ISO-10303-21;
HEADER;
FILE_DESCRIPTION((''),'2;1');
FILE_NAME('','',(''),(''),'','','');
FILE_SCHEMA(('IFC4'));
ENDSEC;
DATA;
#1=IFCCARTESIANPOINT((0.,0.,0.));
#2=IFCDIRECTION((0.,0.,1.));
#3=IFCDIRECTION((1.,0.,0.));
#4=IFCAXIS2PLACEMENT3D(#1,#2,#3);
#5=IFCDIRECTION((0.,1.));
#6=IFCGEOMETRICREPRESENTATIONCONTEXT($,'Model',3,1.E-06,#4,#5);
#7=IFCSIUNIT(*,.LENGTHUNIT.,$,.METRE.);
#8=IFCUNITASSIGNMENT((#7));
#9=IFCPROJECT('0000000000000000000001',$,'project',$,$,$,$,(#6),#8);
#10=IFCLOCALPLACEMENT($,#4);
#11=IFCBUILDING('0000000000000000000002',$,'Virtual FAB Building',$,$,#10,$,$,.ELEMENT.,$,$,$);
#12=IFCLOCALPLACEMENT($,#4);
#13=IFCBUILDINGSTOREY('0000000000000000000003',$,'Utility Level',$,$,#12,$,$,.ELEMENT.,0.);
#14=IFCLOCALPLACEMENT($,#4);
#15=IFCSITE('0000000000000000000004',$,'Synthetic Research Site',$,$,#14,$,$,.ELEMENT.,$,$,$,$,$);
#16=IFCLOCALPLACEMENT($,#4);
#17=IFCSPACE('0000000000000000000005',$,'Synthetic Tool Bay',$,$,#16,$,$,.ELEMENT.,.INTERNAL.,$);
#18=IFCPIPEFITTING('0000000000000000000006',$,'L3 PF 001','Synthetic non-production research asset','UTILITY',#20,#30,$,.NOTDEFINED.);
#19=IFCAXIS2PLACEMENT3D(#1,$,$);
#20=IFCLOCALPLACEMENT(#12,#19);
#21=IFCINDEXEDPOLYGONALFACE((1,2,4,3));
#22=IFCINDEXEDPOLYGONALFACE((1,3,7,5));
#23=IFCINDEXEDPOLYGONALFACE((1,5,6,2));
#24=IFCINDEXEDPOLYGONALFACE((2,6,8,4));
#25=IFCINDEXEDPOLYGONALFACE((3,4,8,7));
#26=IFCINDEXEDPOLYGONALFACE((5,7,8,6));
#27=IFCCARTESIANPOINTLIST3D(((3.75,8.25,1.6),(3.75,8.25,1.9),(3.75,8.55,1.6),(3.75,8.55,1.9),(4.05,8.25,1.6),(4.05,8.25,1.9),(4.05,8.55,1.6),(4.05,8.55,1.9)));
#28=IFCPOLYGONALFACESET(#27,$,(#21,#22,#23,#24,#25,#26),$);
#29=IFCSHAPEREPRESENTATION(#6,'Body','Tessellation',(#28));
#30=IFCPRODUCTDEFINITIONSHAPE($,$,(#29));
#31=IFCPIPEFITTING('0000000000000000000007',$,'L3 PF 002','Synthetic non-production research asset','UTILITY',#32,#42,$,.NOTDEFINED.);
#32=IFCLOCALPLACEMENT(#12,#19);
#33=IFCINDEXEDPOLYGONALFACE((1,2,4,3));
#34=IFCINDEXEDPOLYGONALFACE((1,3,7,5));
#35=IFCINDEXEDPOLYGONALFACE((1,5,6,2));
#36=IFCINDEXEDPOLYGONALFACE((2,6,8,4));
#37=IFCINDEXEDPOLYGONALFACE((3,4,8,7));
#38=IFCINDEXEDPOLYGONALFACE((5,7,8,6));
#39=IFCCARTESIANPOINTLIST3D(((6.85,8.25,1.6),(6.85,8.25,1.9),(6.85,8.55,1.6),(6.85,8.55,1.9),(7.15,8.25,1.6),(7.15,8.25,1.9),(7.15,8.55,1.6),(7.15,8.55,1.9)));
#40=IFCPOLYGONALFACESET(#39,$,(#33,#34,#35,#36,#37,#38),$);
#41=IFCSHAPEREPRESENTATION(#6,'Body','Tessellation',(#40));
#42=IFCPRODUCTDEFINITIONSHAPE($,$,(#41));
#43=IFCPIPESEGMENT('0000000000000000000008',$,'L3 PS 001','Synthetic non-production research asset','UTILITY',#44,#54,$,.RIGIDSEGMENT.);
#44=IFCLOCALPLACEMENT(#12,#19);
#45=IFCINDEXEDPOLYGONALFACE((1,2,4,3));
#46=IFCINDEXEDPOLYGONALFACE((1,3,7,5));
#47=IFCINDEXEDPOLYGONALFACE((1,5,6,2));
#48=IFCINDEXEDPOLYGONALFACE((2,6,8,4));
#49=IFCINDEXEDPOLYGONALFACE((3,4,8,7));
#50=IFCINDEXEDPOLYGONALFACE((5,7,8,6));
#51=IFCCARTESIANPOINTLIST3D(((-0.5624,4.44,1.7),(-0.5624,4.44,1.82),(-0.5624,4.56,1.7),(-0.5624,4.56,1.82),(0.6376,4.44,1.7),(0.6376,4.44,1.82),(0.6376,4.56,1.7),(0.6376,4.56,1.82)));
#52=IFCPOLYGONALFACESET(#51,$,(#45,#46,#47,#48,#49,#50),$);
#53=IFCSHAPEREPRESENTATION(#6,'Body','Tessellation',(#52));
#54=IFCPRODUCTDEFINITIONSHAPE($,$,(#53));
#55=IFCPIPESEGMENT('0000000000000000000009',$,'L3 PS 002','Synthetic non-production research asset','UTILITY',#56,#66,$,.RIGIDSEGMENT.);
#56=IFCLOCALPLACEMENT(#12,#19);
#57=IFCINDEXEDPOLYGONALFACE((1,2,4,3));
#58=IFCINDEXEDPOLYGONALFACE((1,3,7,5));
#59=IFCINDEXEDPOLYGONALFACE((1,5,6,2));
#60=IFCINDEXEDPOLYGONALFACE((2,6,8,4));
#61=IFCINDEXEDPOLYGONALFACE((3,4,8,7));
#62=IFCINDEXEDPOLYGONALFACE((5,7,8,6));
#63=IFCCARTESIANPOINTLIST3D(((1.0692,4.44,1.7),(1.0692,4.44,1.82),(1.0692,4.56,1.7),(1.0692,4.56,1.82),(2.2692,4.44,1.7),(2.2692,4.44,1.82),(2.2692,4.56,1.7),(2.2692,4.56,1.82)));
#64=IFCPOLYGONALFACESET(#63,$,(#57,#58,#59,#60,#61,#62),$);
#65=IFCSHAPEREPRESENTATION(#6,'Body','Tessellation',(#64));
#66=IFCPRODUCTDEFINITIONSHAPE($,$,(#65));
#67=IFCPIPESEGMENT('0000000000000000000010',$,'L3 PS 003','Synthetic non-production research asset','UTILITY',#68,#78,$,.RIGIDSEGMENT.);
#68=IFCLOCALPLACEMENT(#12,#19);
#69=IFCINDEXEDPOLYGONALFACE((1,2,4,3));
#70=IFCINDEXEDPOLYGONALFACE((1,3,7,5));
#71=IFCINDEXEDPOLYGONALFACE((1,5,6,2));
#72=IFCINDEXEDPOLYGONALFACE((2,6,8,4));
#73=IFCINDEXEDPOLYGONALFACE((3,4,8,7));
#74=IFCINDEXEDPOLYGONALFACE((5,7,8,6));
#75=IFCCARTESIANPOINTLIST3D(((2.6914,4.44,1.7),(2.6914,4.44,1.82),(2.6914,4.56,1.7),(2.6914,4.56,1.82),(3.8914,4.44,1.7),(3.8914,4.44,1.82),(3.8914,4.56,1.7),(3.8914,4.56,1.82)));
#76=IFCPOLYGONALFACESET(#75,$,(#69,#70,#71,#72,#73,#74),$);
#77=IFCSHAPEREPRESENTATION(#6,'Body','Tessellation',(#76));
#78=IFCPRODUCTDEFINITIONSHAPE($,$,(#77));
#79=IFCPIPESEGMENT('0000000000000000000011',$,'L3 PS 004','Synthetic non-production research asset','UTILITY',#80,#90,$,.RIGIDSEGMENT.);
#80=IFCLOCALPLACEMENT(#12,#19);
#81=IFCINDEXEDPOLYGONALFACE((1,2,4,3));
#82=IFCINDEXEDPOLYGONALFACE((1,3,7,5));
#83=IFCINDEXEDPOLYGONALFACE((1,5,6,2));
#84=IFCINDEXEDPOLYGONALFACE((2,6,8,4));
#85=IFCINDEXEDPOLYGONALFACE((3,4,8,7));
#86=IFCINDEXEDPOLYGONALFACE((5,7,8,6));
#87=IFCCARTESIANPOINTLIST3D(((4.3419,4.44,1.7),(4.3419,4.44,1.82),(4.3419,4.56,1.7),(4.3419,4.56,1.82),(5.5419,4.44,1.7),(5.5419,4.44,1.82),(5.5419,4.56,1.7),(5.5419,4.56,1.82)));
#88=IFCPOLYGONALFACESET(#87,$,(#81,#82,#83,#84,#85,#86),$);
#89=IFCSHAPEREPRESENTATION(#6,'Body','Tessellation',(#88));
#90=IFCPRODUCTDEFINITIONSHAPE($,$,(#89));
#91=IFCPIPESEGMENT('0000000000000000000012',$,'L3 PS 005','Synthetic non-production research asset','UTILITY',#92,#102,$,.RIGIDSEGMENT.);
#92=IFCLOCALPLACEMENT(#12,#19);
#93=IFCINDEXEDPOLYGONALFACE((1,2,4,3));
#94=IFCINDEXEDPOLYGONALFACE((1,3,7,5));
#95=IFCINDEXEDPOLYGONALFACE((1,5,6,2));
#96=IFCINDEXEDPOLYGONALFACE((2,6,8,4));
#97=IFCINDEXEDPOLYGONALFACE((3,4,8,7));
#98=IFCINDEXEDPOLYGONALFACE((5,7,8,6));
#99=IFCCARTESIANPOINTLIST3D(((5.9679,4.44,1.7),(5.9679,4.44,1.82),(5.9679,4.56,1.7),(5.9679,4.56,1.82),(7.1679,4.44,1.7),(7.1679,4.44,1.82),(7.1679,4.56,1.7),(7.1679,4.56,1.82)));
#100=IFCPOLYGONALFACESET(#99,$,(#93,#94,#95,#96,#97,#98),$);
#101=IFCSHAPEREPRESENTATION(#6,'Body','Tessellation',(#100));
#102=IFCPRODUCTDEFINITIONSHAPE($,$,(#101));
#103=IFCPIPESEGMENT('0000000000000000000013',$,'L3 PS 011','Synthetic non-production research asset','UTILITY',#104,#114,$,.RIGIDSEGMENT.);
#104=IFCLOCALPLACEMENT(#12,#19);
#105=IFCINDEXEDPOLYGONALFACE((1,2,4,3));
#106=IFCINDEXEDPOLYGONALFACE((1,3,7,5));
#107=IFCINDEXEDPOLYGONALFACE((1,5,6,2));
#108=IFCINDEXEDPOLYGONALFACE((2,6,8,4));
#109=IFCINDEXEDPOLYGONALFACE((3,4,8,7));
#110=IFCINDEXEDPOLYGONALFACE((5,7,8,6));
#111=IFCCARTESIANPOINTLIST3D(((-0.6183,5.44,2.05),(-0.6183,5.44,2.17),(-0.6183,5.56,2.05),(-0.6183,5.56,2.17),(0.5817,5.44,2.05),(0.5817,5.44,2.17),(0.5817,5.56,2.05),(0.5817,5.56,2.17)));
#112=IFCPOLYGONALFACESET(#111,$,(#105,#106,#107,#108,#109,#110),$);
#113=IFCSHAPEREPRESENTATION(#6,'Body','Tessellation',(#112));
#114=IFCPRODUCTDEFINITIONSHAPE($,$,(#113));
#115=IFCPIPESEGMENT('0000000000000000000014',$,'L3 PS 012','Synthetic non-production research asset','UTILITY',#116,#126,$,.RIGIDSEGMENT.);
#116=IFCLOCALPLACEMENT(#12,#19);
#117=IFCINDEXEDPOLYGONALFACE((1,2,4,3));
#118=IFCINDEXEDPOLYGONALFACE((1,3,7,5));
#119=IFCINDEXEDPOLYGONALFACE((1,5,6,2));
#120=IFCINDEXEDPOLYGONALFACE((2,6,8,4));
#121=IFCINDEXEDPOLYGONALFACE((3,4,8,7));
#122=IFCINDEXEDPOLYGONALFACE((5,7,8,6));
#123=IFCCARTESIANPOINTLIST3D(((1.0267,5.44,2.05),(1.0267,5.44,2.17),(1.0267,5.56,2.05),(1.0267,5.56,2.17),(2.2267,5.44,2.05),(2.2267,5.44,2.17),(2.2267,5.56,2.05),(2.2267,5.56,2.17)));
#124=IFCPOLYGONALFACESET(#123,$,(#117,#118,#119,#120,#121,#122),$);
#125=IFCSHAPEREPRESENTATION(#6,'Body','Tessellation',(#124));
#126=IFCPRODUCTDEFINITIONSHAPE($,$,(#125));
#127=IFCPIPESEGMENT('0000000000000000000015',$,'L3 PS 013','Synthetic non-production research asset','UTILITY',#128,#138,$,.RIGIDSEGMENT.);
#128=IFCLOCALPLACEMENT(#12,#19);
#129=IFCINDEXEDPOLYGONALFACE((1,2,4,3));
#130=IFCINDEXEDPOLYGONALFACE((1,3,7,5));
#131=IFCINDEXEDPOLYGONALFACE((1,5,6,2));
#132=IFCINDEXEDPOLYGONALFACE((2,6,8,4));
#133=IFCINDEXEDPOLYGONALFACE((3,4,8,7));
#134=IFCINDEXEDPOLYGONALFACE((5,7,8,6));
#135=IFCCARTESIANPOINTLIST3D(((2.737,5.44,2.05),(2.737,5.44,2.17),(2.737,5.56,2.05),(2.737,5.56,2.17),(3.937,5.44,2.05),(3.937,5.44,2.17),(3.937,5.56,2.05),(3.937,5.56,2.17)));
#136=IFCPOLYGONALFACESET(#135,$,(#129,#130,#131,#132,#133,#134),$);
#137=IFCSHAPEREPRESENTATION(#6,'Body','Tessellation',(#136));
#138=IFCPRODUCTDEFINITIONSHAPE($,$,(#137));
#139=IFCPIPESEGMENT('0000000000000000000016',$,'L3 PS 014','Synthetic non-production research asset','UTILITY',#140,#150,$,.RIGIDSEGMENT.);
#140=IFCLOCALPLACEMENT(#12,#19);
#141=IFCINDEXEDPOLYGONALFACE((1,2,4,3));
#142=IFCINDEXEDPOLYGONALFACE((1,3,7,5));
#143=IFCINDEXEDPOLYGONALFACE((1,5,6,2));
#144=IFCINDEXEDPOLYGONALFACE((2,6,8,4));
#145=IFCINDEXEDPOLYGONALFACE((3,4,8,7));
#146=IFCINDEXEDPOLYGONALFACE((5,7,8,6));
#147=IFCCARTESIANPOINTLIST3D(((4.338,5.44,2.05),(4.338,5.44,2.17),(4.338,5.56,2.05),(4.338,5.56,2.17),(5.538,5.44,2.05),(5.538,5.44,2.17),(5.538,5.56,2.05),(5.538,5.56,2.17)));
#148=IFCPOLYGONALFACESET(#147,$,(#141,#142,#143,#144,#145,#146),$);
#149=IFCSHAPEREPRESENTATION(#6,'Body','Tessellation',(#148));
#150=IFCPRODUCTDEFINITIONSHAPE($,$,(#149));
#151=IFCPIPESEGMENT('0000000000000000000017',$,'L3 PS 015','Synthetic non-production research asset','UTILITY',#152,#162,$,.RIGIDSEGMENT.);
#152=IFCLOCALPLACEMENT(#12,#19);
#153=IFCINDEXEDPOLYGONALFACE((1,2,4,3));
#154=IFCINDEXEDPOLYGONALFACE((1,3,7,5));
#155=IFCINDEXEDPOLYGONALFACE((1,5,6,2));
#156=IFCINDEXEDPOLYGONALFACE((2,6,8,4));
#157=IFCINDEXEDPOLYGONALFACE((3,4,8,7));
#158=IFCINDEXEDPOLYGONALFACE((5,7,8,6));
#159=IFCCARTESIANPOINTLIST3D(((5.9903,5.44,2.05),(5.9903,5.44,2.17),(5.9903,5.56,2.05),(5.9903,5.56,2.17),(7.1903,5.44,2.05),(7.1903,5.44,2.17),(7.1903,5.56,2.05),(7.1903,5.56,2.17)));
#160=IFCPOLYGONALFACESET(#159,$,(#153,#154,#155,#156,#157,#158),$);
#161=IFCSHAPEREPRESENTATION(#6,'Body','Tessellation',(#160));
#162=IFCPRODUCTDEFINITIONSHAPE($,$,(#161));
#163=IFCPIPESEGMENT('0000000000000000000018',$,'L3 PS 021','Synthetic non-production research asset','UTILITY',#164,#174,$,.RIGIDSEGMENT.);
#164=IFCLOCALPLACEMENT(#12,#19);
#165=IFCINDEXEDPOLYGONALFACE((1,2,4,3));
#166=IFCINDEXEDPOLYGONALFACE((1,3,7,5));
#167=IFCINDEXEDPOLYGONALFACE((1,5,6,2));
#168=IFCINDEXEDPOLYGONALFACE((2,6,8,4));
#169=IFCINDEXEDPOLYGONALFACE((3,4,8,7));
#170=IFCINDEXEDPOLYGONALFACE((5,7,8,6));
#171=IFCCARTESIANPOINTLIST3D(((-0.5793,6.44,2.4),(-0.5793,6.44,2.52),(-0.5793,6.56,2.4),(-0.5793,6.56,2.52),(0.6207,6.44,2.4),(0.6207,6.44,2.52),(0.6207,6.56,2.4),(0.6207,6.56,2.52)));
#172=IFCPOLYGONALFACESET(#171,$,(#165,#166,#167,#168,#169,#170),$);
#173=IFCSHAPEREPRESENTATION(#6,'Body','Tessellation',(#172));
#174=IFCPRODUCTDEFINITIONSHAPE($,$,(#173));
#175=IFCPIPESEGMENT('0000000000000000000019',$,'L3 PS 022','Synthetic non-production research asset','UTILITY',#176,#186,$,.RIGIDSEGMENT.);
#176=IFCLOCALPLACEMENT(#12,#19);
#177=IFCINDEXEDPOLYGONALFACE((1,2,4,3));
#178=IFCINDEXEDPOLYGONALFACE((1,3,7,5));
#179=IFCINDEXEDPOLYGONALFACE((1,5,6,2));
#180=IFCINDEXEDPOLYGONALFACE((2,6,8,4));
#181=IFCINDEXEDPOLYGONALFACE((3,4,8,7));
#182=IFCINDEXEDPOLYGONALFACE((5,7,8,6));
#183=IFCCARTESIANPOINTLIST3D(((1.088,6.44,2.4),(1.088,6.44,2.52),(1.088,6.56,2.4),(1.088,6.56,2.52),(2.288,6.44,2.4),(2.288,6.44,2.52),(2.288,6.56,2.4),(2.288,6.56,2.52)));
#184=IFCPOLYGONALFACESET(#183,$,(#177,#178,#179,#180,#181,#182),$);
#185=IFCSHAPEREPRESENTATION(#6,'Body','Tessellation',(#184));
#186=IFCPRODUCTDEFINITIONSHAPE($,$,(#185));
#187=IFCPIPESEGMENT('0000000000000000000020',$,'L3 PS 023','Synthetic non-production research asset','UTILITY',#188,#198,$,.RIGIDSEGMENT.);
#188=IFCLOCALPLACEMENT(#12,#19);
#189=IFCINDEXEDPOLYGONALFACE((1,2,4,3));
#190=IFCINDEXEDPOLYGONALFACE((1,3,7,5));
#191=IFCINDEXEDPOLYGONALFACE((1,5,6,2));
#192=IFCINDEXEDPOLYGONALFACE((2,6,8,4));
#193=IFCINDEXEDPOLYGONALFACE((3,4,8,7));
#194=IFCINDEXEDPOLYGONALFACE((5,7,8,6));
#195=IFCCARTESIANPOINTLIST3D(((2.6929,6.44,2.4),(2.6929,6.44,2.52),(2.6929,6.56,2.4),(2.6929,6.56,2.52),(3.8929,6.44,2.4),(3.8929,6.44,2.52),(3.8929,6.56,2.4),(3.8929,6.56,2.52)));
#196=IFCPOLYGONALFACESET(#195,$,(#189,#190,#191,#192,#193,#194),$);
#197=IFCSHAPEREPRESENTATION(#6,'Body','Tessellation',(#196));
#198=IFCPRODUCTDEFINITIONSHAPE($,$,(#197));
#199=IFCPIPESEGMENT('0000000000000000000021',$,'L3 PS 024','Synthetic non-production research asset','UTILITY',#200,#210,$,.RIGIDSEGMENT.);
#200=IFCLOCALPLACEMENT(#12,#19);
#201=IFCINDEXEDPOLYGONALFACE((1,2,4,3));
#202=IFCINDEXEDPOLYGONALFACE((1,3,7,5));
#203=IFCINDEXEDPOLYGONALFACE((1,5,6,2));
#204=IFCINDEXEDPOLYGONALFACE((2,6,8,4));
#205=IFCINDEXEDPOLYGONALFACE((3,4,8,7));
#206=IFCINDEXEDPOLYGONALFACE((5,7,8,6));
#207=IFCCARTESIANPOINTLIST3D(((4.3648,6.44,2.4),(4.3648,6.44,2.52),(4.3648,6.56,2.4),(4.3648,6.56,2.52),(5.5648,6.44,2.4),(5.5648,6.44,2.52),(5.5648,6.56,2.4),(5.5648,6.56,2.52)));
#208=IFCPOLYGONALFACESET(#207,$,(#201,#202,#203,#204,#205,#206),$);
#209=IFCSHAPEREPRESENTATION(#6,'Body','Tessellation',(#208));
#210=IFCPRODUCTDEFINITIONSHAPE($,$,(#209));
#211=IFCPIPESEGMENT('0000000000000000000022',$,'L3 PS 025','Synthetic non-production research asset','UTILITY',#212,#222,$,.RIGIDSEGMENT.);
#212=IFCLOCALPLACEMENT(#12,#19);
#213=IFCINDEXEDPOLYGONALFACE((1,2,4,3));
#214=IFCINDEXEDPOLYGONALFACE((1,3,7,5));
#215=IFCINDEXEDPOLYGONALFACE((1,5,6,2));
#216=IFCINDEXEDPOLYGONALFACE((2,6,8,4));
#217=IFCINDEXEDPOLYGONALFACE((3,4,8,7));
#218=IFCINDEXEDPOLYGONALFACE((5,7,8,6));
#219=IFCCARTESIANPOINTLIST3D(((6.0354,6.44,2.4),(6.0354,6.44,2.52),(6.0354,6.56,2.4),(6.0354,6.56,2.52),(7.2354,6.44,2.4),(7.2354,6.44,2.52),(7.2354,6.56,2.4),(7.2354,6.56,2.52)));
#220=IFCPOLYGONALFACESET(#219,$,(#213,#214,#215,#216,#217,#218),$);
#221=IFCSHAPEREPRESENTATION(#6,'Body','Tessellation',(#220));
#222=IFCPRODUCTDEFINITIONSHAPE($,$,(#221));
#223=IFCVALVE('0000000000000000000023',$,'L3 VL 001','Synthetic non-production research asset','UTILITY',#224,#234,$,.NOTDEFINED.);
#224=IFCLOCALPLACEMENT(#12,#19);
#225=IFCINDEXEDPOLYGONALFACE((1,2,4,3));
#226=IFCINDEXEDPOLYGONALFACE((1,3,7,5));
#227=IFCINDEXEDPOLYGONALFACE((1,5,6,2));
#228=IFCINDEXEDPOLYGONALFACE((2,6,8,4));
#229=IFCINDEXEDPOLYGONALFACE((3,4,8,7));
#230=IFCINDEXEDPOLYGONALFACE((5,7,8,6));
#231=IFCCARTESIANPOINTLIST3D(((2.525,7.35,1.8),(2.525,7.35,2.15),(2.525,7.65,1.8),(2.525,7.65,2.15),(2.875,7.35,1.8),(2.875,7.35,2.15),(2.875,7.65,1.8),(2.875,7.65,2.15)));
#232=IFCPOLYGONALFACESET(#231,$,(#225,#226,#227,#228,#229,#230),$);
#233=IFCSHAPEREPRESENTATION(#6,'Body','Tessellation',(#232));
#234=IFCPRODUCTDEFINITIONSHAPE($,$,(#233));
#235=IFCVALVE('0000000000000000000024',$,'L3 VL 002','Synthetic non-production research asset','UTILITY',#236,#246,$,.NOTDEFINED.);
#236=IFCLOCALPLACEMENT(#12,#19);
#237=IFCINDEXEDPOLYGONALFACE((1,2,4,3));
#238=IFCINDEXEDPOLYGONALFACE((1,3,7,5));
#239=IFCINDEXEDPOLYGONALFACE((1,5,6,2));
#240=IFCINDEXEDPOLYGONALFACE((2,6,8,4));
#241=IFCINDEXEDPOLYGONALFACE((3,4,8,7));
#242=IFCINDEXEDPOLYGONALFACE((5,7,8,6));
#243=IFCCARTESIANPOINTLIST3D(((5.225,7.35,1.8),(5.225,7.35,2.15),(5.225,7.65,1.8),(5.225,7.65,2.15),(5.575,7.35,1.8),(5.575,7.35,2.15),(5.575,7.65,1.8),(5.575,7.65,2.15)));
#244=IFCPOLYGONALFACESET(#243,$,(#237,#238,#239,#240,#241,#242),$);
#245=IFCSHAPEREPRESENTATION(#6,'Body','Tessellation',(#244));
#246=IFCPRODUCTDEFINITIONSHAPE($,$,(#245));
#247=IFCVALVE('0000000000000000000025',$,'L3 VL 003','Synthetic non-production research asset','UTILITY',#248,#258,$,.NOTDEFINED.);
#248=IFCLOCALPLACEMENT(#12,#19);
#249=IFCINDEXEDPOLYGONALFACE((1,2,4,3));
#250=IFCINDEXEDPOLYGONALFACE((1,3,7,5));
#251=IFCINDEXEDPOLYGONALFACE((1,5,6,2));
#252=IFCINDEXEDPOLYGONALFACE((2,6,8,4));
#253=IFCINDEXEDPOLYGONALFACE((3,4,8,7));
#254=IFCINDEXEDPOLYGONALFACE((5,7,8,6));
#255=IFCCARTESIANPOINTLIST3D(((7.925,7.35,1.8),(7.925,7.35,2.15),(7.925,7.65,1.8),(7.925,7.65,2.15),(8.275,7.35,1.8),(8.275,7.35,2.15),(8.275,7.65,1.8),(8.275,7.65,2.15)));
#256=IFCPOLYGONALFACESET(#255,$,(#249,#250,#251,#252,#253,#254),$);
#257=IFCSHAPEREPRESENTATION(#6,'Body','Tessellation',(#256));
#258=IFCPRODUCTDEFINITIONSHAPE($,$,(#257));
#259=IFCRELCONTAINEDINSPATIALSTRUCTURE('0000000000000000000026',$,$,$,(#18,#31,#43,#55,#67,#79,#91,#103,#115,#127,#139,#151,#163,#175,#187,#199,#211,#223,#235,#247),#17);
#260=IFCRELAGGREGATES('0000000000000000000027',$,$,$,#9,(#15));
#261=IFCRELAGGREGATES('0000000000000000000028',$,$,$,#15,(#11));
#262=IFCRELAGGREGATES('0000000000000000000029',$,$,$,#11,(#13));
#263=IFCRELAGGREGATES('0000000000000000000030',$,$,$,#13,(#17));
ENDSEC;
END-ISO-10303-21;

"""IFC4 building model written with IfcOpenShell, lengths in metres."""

from ifc_helpers import new_model, si_unit, direction, frame, origin_with_axes, origin_2d_with_axis, place, context, project, spatial, rectangle, extrude, element, save


model = new_model("IFC4")

# Units and contexts
model_context = context("Model", 3, precision=1e-06, world=origin_with_axes(), true_north=direction((0.0, 1.0)))
ifc_project = project(units=[si_unit("LENGTHUNIT", "METRE")], contexts=[model_context])

# Site, building, storey, space
site_placement = place(None, origin_with_axes())
site = spatial("IfcSite", under=ifc_project, at=site_placement, Name="Synthetic Research Site", CompositionType="ELEMENT")
building_placement = place(None, origin_with_axes())
building = spatial("IfcBuilding", under=site, at=building_placement, Name="Virtual FAB Building", CompositionType="ELEMENT")
storey_placement = place(None, origin_with_axes())
storey = spatial("IfcBuildingStorey", under=building, at=storey_placement, Name="Utility Level", CompositionType="ELEMENT", Elevation=0.0)
space_placement = place(None, origin_with_axes())
space = spatial("IfcSpace", under=storey, at=space_placement, Name="Synthetic Tool Bay", CompositionType="ELEMENT", PredefinedType="INTERNAL")

# Pipe fittings
for number, where, z_axis, x_axis, name in (
    (1, (3.9, 8.4, 1.6), (0.0, 0.0, 1.0), (1.0, 0.0, 0.0), "L3 PF 001"),
    (2, (7.0, 8.4, 1.6), (0.0, 0.0, 1.0), (1.0, 0.0, 0.0), "L3 PF 002"),
):
    element("IfcPipeFitting", number, at=place(None, frame(where, z_axis=z_axis, x_axis=x_axis)), inside=space, Name=name, Description="Synthetic non-production research asset", ObjectType="UTILITY", PredefinedType="NOTDEFINED", context=model_context, shape_type="SweptSolid", body=[
        extrude(rectangle(XDim=0.3, YDim=0.3, at=origin_2d_with_axis()), origin_with_axes(), (0.0, 0.0, 1.0), 0.3),
    ])

# Pipe segments
for number, where, z_axis, x_axis, name in (
    (3, (0.0376, 4.5, 1.7), (0.0, 0.0, 1.0), (1.0, 0.0, 0.0), "L3 PS 001"),
    (4, (1.6692, 4.5, 1.7), (0.0, 0.0, 1.0), (1.0, 0.0, 0.0), "L3 PS 002"),
    (5, (3.2914, 4.5, 1.7), (0.0, 0.0, 1.0), (1.0, 0.0, 0.0), "L3 PS 003"),
    (6, (4.9419, 4.5, 1.7), (0.0, 0.0, 1.0), (1.0, 0.0, 0.0), "L3 PS 004"),
    (7, (6.5679, 4.5, 1.7), (0.0, 0.0, 1.0), (1.0, 0.0, 0.0), "L3 PS 005"),
    (8, (-0.0183, 5.5, 2.05), (0.0, 0.0, 1.0), (1.0, 0.0, 0.0), "L3 PS 011"),
    (9, (1.6267, 5.5, 2.05), (0.0, 0.0, 1.0), (1.0, 0.0, 0.0), "L3 PS 012"),
    (10, (3.337, 5.5, 2.05), (0.0, 0.0, 1.0), (1.0, 0.0, 0.0), "L3 PS 013"),
    (11, (4.938, 5.5, 2.05), (0.0, 0.0, 1.0), (1.0, 0.0, 0.0), "L3 PS 014"),
    (12, (6.5903, 5.5, 2.05), (0.0, 0.0, 1.0), (1.0, 0.0, 0.0), "L3 PS 015"),
    (13, (0.0207, 6.5, 2.4), (0.0, 0.0, 1.0), (1.0, 0.0, 0.0), "L3 PS 021"),
    (14, (1.688, 6.5, 2.4), (0.0, 0.0, 1.0), (1.0, 0.0, 0.0), "L3 PS 022"),
    (15, (3.2929, 6.5, 2.4), (0.0, 0.0, 1.0), (1.0, 0.0, 0.0), "L3 PS 023"),
    (16, (4.9648, 6.5, 2.4), (0.0, 0.0, 1.0), (1.0, 0.0, 0.0), "L3 PS 024"),
    (17, (6.6354, 6.5, 2.4), (0.0, 0.0, 1.0), (1.0, 0.0, 0.0), "L3 PS 025"),
):
    element("IfcPipeSegment", number, at=place(None, frame(where, z_axis=z_axis, x_axis=x_axis)), inside=space, Name=name, Description="Synthetic non-production research asset", ObjectType="UTILITY", PredefinedType="RIGIDSEGMENT", context=model_context, shape_type="SweptSolid", body=[
        extrude(rectangle(XDim=1.2, YDim=0.12, at=origin_2d_with_axis()), origin_with_axes(), (0.0, 0.0, 1.0), 0.12),
    ])

# Valves
for number, where, z_axis, x_axis, name in (
    (18, (2.7, 7.5, 1.8), (0.0, 0.0, 1.0), (1.0, 0.0, 0.0), "L3 VL 001"),
    (19, (5.4, 7.5, 1.8), (0.0, 0.0, 1.0), (1.0, 0.0, 0.0), "L3 VL 002"),
    (20, (8.1, 7.5, 1.8), (0.0, 0.0, 1.0), (1.0, 0.0, 0.0), "L3 VL 003"),
):
    element("IfcValve", number, at=place(None, frame(where, z_axis=z_axis, x_axis=x_axis)), inside=space, Name=name, Description="Synthetic non-production research asset", ObjectType="UTILITY", PredefinedType="NOTDEFINED", context=model_context, shape_type="SweptSolid", body=[
        extrude(rectangle(XDim=0.35, YDim=0.3, at=origin_2d_with_axis()), origin_with_axes(), (0.0, 0.0, 1.0), 0.35),
    ])

save(model, "model.ifc")
